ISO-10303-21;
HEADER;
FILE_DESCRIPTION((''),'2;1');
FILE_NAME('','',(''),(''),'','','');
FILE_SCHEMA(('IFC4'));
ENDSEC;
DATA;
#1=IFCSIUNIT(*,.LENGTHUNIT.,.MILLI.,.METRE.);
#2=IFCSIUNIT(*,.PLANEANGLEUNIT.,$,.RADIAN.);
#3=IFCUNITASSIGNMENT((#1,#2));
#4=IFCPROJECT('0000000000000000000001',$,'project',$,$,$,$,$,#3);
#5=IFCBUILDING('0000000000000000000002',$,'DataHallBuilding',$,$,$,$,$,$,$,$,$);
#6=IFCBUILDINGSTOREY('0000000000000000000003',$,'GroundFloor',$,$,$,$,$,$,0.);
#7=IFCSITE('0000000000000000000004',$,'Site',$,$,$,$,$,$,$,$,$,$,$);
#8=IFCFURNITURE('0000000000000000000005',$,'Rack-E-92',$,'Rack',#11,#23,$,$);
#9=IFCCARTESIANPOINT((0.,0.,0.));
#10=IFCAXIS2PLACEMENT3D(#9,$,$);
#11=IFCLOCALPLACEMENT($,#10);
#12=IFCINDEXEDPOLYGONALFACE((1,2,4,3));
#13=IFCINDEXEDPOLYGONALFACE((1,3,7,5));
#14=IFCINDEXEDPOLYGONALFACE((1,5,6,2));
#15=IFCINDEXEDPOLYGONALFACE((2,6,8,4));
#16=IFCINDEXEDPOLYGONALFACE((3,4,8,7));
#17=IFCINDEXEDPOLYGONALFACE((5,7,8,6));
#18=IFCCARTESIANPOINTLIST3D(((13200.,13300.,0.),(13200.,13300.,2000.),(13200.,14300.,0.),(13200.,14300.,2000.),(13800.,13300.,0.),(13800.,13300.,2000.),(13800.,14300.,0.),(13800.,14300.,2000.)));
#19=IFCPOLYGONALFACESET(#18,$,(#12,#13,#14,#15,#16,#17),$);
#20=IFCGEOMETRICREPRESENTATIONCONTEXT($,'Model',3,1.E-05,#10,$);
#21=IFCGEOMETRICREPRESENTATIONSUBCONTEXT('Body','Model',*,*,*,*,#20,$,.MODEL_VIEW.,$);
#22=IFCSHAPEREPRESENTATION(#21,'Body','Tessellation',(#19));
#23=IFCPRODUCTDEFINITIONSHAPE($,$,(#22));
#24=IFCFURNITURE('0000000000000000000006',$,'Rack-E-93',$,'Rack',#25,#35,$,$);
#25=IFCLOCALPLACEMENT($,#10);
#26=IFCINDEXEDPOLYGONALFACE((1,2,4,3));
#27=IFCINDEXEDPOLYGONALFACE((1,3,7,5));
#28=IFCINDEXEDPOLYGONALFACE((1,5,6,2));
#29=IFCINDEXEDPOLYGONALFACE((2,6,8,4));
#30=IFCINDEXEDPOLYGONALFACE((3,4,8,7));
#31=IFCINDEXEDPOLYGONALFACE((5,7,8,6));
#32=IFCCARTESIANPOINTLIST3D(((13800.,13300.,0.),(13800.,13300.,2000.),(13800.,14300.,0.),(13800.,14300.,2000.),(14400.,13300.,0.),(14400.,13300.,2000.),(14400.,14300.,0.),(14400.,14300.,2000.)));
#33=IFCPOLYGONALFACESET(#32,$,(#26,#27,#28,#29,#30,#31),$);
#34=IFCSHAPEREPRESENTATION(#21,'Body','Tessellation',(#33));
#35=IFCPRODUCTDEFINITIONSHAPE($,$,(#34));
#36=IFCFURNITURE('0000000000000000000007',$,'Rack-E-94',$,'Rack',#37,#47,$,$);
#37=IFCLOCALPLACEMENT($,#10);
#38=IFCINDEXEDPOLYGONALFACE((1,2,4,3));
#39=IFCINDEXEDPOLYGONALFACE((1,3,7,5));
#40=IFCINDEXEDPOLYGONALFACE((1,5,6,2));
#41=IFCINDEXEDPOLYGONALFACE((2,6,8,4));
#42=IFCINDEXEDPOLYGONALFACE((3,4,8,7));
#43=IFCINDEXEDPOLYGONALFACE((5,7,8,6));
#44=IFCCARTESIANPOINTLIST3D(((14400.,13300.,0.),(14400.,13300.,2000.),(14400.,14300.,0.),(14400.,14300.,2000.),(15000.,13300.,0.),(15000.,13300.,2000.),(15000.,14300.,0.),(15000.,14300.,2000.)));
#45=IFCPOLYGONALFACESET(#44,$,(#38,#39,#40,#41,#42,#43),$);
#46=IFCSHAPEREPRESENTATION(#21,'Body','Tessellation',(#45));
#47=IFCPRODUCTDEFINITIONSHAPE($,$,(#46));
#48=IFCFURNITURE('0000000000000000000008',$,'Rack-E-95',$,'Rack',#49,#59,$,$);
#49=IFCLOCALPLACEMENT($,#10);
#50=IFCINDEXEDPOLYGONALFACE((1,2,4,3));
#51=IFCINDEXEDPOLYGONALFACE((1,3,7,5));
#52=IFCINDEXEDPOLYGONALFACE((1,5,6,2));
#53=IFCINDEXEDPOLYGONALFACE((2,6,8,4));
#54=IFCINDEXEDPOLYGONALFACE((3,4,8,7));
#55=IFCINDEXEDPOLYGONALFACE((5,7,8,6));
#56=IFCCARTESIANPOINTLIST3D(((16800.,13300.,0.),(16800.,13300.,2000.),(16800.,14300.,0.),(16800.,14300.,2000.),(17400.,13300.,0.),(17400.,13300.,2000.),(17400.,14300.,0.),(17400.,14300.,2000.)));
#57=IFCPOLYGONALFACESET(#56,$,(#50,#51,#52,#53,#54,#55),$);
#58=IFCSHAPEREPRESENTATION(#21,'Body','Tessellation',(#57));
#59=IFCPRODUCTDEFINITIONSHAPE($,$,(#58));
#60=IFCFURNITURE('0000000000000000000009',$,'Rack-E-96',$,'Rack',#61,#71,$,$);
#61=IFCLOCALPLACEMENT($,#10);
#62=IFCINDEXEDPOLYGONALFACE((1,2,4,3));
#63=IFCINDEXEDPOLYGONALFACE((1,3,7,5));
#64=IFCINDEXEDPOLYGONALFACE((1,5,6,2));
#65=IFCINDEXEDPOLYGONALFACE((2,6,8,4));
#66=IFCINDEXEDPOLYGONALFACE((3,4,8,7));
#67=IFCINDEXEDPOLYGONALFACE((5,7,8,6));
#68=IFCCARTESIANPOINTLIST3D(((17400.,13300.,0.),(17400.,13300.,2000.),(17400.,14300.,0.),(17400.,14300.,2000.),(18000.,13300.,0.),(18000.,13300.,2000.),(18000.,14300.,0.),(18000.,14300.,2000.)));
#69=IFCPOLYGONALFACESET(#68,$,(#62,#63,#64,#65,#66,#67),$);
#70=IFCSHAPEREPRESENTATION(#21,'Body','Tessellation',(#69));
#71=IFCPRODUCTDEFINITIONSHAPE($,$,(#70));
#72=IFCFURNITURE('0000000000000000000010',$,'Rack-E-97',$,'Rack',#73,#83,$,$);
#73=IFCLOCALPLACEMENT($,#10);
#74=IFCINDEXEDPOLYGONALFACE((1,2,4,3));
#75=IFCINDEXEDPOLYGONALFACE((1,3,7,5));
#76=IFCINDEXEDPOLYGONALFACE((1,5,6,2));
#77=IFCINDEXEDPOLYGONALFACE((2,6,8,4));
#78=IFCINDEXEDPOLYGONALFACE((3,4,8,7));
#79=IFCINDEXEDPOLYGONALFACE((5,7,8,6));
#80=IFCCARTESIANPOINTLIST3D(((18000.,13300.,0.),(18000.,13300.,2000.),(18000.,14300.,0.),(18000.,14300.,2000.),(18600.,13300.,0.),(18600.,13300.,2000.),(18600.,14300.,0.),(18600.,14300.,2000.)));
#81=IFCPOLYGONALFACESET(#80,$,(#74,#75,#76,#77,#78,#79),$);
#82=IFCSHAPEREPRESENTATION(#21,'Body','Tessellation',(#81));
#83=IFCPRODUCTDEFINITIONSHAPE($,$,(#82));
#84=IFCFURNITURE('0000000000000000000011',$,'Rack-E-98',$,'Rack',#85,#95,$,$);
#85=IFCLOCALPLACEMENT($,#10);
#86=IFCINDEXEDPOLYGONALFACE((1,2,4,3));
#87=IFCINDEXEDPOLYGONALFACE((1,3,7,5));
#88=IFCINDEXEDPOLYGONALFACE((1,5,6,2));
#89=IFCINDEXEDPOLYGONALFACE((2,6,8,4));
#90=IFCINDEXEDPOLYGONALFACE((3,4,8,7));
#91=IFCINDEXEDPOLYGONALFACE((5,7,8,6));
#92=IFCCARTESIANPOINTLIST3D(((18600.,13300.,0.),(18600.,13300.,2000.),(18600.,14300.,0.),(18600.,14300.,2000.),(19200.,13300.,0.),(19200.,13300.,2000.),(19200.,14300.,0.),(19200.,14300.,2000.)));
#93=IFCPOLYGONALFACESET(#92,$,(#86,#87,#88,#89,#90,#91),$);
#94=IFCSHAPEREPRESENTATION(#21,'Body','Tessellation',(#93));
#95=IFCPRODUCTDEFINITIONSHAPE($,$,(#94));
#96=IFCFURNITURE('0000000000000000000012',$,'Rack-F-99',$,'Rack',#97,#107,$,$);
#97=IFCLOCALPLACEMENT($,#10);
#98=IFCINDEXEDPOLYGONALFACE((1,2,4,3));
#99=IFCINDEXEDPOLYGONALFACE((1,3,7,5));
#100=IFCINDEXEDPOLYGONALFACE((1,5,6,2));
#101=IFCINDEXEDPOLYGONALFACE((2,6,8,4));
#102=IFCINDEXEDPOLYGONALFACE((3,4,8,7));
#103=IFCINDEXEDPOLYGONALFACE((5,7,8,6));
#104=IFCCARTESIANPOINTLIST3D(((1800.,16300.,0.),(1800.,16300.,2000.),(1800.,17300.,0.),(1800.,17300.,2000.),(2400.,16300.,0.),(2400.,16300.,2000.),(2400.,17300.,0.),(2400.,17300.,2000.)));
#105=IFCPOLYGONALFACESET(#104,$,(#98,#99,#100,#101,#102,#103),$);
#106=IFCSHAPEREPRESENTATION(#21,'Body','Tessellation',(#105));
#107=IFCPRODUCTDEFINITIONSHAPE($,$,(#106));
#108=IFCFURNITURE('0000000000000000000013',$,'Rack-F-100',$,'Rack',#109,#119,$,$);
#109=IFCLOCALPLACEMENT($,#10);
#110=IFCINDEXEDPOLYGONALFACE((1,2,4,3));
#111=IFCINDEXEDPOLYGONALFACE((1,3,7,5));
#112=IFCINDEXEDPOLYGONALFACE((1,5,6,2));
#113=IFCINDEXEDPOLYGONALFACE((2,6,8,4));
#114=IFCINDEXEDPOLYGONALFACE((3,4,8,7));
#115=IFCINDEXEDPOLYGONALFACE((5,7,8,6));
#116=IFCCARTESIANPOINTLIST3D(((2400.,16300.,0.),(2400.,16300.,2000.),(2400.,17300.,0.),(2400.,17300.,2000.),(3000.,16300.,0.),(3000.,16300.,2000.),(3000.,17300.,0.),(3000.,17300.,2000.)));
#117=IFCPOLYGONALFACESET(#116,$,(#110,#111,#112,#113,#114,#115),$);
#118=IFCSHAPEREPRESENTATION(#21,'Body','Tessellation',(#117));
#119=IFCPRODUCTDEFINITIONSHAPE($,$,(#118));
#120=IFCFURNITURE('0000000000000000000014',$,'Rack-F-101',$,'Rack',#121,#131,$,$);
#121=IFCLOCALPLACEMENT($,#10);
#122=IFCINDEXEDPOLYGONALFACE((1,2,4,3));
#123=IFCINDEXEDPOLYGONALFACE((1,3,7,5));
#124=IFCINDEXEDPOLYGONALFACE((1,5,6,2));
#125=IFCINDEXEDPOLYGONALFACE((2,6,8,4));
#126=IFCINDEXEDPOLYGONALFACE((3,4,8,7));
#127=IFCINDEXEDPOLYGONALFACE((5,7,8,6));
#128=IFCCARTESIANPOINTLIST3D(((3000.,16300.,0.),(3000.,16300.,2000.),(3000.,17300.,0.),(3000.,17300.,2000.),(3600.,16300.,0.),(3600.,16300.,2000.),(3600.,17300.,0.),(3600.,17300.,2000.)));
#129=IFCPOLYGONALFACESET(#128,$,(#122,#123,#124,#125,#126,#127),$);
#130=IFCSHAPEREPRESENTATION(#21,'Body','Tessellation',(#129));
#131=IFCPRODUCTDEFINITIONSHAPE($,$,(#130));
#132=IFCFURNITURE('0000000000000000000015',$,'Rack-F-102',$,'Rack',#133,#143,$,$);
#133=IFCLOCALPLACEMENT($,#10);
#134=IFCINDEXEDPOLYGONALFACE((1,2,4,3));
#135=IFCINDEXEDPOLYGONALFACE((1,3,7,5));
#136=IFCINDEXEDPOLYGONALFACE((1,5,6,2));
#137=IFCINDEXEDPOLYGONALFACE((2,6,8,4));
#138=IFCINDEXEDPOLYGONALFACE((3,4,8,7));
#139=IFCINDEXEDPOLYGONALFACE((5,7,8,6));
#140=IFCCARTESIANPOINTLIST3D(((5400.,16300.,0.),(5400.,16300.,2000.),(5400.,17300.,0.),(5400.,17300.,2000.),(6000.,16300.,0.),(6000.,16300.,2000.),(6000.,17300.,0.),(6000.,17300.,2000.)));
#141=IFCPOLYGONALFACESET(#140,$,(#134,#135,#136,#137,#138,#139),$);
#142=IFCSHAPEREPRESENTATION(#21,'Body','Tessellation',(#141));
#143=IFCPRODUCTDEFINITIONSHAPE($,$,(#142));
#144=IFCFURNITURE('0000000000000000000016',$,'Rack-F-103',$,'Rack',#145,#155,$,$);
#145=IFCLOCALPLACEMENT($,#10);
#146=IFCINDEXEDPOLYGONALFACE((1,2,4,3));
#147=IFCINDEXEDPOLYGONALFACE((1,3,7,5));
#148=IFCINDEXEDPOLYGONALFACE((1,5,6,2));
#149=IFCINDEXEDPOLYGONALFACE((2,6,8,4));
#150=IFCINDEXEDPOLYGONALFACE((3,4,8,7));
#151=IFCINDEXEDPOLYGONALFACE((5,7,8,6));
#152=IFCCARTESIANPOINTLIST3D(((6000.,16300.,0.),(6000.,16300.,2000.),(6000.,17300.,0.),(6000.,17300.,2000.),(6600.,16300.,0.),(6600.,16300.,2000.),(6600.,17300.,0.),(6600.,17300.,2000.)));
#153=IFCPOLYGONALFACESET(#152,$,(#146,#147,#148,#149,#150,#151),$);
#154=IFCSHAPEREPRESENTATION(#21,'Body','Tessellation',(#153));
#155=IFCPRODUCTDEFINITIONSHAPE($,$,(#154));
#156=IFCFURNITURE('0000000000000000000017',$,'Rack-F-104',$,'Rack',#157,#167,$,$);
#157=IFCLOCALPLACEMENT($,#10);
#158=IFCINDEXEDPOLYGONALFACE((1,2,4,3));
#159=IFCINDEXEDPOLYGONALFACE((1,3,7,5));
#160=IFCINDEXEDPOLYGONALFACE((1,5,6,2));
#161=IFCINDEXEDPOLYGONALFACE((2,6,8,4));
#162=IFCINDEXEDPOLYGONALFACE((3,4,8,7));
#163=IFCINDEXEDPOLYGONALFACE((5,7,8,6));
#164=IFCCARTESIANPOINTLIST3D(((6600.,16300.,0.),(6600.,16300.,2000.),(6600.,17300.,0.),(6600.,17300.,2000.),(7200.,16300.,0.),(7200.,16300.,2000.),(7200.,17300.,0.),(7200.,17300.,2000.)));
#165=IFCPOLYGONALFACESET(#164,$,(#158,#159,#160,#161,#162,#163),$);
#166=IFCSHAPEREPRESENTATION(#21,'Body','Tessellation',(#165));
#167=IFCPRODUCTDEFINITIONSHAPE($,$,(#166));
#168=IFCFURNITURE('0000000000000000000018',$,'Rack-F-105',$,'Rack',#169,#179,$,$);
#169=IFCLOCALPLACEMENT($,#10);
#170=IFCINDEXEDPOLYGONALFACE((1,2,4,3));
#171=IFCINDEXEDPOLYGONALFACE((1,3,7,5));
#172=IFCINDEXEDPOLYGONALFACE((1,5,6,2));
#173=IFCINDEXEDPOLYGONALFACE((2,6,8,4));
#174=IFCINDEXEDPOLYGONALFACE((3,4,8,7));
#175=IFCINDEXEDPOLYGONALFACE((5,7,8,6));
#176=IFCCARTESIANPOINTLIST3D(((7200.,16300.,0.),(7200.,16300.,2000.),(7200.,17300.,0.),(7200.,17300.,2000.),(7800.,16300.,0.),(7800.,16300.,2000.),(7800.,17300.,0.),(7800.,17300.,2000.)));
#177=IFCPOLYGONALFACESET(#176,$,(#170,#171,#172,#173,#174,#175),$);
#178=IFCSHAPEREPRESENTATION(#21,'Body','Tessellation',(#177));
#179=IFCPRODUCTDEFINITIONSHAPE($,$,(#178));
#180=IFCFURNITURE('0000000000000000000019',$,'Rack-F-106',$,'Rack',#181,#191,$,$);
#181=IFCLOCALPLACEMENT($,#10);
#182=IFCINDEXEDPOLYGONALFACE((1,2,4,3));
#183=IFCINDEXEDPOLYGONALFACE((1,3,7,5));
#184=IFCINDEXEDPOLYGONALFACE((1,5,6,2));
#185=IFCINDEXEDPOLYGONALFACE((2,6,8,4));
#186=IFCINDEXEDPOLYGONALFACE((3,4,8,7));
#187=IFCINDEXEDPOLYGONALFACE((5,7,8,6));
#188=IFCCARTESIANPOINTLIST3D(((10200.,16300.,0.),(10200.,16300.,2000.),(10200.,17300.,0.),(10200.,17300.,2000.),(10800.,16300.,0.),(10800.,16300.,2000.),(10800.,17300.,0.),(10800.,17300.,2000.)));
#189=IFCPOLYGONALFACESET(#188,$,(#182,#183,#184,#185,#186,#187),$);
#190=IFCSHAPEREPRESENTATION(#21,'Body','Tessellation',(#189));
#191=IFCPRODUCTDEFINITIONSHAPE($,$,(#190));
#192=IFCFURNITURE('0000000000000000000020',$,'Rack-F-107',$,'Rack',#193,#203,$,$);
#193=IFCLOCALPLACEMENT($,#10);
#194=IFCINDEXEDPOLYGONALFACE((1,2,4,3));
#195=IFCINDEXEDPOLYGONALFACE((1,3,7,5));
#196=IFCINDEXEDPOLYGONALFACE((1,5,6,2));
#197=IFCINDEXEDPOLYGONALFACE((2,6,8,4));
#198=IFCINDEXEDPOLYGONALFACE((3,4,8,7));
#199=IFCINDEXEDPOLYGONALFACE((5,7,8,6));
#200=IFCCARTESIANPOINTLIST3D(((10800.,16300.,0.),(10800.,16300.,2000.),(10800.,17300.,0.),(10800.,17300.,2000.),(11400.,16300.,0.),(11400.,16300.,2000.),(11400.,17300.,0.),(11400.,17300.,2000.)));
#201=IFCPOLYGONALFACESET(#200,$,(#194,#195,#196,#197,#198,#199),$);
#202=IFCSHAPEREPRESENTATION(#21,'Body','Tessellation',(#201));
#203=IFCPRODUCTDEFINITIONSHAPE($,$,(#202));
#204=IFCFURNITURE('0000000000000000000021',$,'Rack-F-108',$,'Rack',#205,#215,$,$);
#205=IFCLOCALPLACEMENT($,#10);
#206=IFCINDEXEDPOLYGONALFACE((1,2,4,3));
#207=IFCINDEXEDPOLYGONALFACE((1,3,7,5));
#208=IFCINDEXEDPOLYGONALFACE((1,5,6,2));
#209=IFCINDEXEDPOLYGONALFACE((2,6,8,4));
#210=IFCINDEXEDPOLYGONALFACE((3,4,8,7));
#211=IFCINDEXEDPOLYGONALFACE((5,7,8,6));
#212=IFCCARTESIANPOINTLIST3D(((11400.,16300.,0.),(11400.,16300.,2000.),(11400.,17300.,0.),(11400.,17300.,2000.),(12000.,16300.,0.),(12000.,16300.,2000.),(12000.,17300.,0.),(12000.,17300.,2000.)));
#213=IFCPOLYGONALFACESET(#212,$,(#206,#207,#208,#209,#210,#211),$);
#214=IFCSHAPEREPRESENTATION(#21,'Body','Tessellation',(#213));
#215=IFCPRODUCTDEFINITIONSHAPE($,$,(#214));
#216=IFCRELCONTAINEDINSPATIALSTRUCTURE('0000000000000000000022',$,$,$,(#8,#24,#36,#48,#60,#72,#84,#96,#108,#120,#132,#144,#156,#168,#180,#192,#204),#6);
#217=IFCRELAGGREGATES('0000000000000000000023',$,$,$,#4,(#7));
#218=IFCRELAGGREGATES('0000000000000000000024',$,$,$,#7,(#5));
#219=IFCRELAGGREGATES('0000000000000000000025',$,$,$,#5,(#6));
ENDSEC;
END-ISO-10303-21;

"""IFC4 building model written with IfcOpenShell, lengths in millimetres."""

from ifc_helpers import new_model, si_unit, frame, origin, place, context, subcontext, project, spatial, rectangle, extrude, element, save


model = new_model("IFC4")

# Units and contexts
model_context = context("Model", 3, precision=1e-05, world=origin())
body_context = subcontext(model_context, "Body", "Model", "MODEL_VIEW")
ifc_project = project(units=[si_unit("LENGTHUNIT", "METRE", prefix="MILLI"), si_unit("PLANEANGLEUNIT", "RADIAN")])

# Site, building, storey
site = spatial("IfcSite", under=ifc_project, Name="Site")
building = spatial("IfcBuilding", under=site, Name="DataHallBuilding")
storey = spatial("IfcBuildingStorey", under=building, Name="GroundFloor", Elevation=0.0)

# Furniture
furniture_1_placement = place(None, origin())
element("IfcFurniture", 1, at=furniture_1_placement, inside=storey, Name="Rack-E-92", ObjectType="Rack", context=body_context, shape_type="SweptSolid", body=[
    extrude(rectangle(XDim=600.0, YDim=1000.0), frame((13500.0, 13800.0, 0.0), z_axis=(0.0, 0.0, 1.0), x_axis=(1.0, 0.0, 0.0)), (0.0, 0.0, 1.0), 2000.0),
])
furniture_2_placement = place(None, origin())
element("IfcFurniture", 2, at=furniture_2_placement, inside=storey, Name="Rack-E-93", ObjectType="Rack", context=body_context, shape_type="SweptSolid", body=[
    extrude(rectangle(XDim=600.0, YDim=1000.0), frame((14100.0, 13800.0, 0.0), z_axis=(0.0, 0.0, 1.0), x_axis=(1.0, 0.0, 0.0)), (0.0, 0.0, 1.0), 2000.0),
])
furniture_3_placement = place(None, origin())
element("IfcFurniture", 3, at=furniture_3_placement, inside=storey, Name="Rack-E-94", ObjectType="Rack", context=body_context, shape_type="SweptSolid", body=[
    extrude(rectangle(XDim=600.0, YDim=1000.0), frame((14700.0, 13800.0, 0.0), z_axis=(0.0, 0.0, 1.0), x_axis=(1.0, 0.0, 0.0)), (0.0, 0.0, 1.0), 2000.0),
])
furniture_4_placement = place(None, origin())
element("IfcFurniture", 4, at=furniture_4_placement, inside=storey, Name="Rack-E-95", ObjectType="Rack", context=body_context, shape_type="SweptSolid", body=[
    extrude(rectangle(XDim=600.0, YDim=1000.0), frame((17100.0, 13800.0, 0.0), z_axis=(0.0, 0.0, 1.0), x_axis=(1.0, 0.0, 0.0)), (0.0, 0.0, 1.0), 2000.0),
])
furniture_5_placement = place(None, origin())
element("IfcFurniture", 5, at=furniture_5_placement, inside=storey, Name="Rack-E-96", ObjectType="Rack", context=body_context, shape_type="SweptSolid", body=[
    extrude(rectangle(XDim=600.0, YDim=1000.0), frame((17700.0, 13800.0, 0.0), z_axis=(0.0, 0.0, 1.0), x_axis=(1.0, 0.0, 0.0)), (0.0, 0.0, 1.0), 2000.0),
])
furniture_6_placement = place(None, origin())
element("IfcFurniture", 6, at=furniture_6_placement, inside=storey, Name="Rack-E-97", ObjectType="Rack", context=body_context, shape_type="SweptSolid", body=[
    extrude(rectangle(XDim=600.0, YDim=1000.0), frame((18300.0, 13800.0, 0.0), z_axis=(0.0, 0.0, 1.0), x_axis=(1.0, 0.0, 0.0)), (0.0, 0.0, 1.0), 2000.0),
])
furniture_7_placement = place(None, origin())
element("IfcFurniture", 7, at=furniture_7_placement, inside=storey, Name="Rack-E-98", ObjectType="Rack", context=body_context, shape_type="SweptSolid", body=[
    extrude(rectangle(XDim=600.0, YDim=1000.0), frame((18900.0, 13800.0, 0.0), z_axis=(0.0, 0.0, 1.0), x_axis=(1.0, 0.0, 0.0)), (0.0, 0.0, 1.0), 2000.0),
])
furniture_8_placement = place(None, origin())
element("IfcFurniture", 8, at=furniture_8_placement, inside=storey, Name="Rack-F-99", ObjectType="Rack", context=body_context, shape_type="SweptSolid", body=[
    extrude(rectangle(XDim=600.0, YDim=1000.0), frame((2100.0, 16800.0, 0.0), z_axis=(0.0, 0.0, 1.0), x_axis=(1.0, 0.0, 0.0)), (0.0, 0.0, 1.0), 2000.0),
])
furniture_9_placement = place(None, origin())
element("IfcFurniture", 9, at=furniture_9_placement, inside=storey, Name="Rack-F-100", ObjectType="Rack", context=body_context, shape_type="SweptSolid", body=[
    extrude(rectangle(XDim=600.0, YDim=1000.0), frame((2700.0, 16800.0, 0.0), z_axis=(0.0, 0.0, 1.0), x_axis=(1.0, 0.0, 0.0)), (0.0, 0.0, 1.0), 2000.0),
])
furniture_10_placement = place(None, origin())
element("IfcFurniture", 10, at=furniture_10_placement, inside=storey, Name="Rack-F-101", ObjectType="Rack", context=body_context, shape_type="SweptSolid", body=[
    extrude(rectangle(XDim=600.0, YDim=1000.0), frame((3300.0, 16800.0, 0.0), z_axis=(0.0, 0.0, 1.0), x_axis=(1.0, 0.0, 0.0)), (0.0, 0.0, 1.0), 2000.0),
])
furniture_11_placement = place(None, origin())
element("IfcFurniture", 11, at=furniture_11_placement, inside=storey, Name="Rack-F-102", ObjectType="Rack", context=body_context, shape_type="SweptSolid", body=[
    extrude(rectangle(XDim=600.0, YDim=1000.0), frame((5700.0, 16800.0, 0.0), z_axis=(0.0, 0.0, 1.0), x_axis=(1.0, 0.0, 0.0)), (0.0, 0.0, 1.0), 2000.0),
])
furniture_12_placement = place(None, origin())
element("IfcFurniture", 12, at=furniture_12_placement, inside=storey, Name="Rack-F-103", ObjectType="Rack", context=body_context, shape_type="SweptSolid", body=[
    extrude(rectangle(XDim=600.0, YDim=1000.0), frame((6300.0, 16800.0, 0.0), z_axis=(0.0, 0.0, 1.0), x_axis=(1.0, 0.0, 0.0)), (0.0, 0.0, 1.0), 2000.0),
])
furniture_13_placement = place(None, origin())
element("IfcFurniture", 13, at=furniture_13_placement, inside=storey, Name="Rack-F-104", ObjectType="Rack", context=body_context, shape_type="SweptSolid", body=[
    extrude(rectangle(XDim=600.0, YDim=1000.0), frame((6900.0, 16800.0, 0.0), z_axis=(0.0, 0.0, 1.0), x_axis=(1.0, 0.0, 0.0)), (0.0, 0.0, 1.0), 2000.0),
])
furniture_14_placement = place(None, origin())
element("IfcFurniture", 14, at=furniture_14_placement, inside=storey, Name="Rack-F-105", ObjectType="Rack", context=body_context, shape_type="SweptSolid", body=[
    extrude(rectangle(XDim=600.0, YDim=1000.0), frame((7500.0, 16800.0, 0.0), z_axis=(0.0, 0.0, 1.0), x_axis=(1.0, 0.0, 0.0)), (0.0, 0.0, 1.0), 2000.0),
])
furniture_15_placement = place(None, origin())
element("IfcFurniture", 15, at=furniture_15_placement, inside=storey, Name="Rack-F-106", ObjectType="Rack", context=body_context, shape_type="SweptSolid", body=[
    extrude(rectangle(XDim=600.0, YDim=1000.0), frame((10500.0, 16800.0, 0.0), z_axis=(0.0, 0.0, 1.0), x_axis=(1.0, 0.0, 0.0)), (0.0, 0.0, 1.0), 2000.0),
])
furniture_16_placement = place(None, origin())
element("IfcFurniture", 16, at=furniture_16_placement, inside=storey, Name="Rack-F-107", ObjectType="Rack", context=body_context, shape_type="SweptSolid", body=[
    extrude(rectangle(XDim=600.0, YDim=1000.0), frame((11100.0, 16800.0, 0.0), z_axis=(0.0, 0.0, 1.0), x_axis=(1.0, 0.0, 0.0)), (0.0, 0.0, 1.0), 2000.0),
])
furniture_17_placement = place(None, origin())
element("IfcFurniture", 17, at=furniture_17_placement, inside=storey, Name="Rack-F-108", ObjectType="Rack", context=body_context, shape_type="SweptSolid", body=[
    extrude(rectangle(XDim=600.0, YDim=1000.0), frame((11700.0, 16800.0, 0.0), z_axis=(0.0, 0.0, 1.0), x_axis=(1.0, 0.0, 0.0)), (0.0, 0.0, 1.0), 2000.0),
])

save(model, "model.ifc")
